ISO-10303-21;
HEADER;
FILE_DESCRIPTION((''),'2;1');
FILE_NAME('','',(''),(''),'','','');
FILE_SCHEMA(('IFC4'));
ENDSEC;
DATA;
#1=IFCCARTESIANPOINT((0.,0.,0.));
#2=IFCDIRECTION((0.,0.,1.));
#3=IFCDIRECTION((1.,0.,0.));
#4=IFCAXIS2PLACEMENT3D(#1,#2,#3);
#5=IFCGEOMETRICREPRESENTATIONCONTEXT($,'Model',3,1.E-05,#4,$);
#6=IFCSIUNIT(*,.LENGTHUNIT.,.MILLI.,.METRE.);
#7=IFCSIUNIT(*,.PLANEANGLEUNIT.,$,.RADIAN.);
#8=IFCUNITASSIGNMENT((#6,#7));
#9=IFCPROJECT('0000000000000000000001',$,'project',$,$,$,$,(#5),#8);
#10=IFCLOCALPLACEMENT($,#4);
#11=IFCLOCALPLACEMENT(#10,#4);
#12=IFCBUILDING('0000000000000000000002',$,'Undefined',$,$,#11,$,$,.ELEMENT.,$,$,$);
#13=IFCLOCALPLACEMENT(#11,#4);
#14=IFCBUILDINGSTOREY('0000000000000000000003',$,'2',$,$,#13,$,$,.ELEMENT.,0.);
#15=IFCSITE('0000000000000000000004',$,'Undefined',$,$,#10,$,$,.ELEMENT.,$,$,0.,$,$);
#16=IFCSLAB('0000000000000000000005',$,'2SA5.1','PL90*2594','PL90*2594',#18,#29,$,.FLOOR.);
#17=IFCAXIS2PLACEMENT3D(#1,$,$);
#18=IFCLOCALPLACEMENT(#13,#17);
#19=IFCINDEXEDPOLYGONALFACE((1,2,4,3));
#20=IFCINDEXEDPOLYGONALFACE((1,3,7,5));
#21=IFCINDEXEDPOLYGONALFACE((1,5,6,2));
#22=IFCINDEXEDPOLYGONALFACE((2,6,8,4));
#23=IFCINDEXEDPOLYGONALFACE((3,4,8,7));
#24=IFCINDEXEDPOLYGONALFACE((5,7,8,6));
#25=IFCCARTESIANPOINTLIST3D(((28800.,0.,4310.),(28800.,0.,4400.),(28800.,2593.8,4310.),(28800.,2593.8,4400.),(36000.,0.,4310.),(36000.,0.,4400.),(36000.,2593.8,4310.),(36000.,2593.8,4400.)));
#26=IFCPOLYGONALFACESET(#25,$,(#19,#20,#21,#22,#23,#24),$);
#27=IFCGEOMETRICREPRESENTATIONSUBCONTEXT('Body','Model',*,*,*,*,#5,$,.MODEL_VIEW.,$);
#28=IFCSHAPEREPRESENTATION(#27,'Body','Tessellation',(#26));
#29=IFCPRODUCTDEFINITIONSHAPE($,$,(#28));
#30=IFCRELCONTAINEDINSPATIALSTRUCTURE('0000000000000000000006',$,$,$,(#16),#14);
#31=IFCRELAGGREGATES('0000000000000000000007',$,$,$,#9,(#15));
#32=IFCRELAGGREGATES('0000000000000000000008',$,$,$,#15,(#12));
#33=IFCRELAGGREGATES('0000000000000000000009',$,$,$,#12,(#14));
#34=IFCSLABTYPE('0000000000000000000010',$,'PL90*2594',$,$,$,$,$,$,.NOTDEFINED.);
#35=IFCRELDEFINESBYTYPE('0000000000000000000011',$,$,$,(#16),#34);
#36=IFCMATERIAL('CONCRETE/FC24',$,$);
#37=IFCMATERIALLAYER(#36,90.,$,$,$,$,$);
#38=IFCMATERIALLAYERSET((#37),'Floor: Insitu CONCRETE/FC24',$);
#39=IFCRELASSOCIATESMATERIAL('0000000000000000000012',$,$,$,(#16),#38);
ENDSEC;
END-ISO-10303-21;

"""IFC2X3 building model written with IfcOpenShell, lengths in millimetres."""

from ifc_helpers import new_model, si_unit, frame, origin_with_axes, place, context, subcontext, project, spatial, polyline, outline, extrude, material, layer, layer_set, layer_usage, type_object, element, save


model = new_model("IFC2X3")

# Units and contexts
model_context = context("Model", 3, precision=1e-05, world=origin_with_axes())
body_context = subcontext(model_context, "Body", "Model", "MODEL_VIEW")
ifc_project = project(units=[si_unit("LENGTHUNIT", "METRE", prefix="MILLI"), si_unit("PLANEANGLEUNIT", "RADIAN")], contexts=[model_context])

# Site, building, storey
site_placement = place(None, origin_with_axes())
site = spatial("IfcSite", under=ifc_project, at=site_placement, Name="Undefined", CompositionType="ELEMENT", RefElevation=0.0)
building_placement = place(site_placement, origin_with_axes())
building = spatial("IfcBuilding", under=site, at=building_placement, Name="Undefined", CompositionType="ELEMENT")
storey_placement = place(building_placement, origin_with_axes())
storey = spatial("IfcBuildingStorey", under=building, at=storey_placement, Name="2", CompositionType="ELEMENT", Elevation=0.0)

# Slab
ifc_material_1 = material(Name="CONCRETE/FC24")
ifc_layer = layer(ifc_material_1, 90.0)
ifc_layer_set = layer_set([ifc_layer], Name="Floor: Insitu CONCRETE/FC24")
slab_type_1 = type_object("IfcSlabType", Name="PL90*2594", PredefinedType="NOTDEFINED")
ifc_layer_usage_1 = layer_usage(ifc_layer_set, "AXIS3", "POSITIVE", -45.0)
slab_1_placement = place(storey_placement, frame((28800.0, 0.0, 4355.0), z_axis=(0.0, 0.0, 1.0), x_axis=(1.0, 0.0, 0.0)))
element("IfcSlab", 1, at=slab_1_placement, inside=storey, type_object=slab_type_1, material=ifc_layer_usage_1, Name="2SA5.1", Description="PL90*2594", ObjectType="PL90*2594", PredefinedType="FLOOR", context=body_context, shape_type="SweptSolid", body=[
    extrude(outline(polyline([(0.0, 0.0), (7200.0, 0.0), (7200.0, 2593.8), (0.0, 2593.8), (0.0, 0.0)])), frame((0.0, 0.0, -45.0), z_axis=(0.0, 0.0, 1.0), x_axis=(1.0, 0.0, 0.0)), (0.0, 0.0, 1.0), 90.0),
])

save(model, "model.ifc")
